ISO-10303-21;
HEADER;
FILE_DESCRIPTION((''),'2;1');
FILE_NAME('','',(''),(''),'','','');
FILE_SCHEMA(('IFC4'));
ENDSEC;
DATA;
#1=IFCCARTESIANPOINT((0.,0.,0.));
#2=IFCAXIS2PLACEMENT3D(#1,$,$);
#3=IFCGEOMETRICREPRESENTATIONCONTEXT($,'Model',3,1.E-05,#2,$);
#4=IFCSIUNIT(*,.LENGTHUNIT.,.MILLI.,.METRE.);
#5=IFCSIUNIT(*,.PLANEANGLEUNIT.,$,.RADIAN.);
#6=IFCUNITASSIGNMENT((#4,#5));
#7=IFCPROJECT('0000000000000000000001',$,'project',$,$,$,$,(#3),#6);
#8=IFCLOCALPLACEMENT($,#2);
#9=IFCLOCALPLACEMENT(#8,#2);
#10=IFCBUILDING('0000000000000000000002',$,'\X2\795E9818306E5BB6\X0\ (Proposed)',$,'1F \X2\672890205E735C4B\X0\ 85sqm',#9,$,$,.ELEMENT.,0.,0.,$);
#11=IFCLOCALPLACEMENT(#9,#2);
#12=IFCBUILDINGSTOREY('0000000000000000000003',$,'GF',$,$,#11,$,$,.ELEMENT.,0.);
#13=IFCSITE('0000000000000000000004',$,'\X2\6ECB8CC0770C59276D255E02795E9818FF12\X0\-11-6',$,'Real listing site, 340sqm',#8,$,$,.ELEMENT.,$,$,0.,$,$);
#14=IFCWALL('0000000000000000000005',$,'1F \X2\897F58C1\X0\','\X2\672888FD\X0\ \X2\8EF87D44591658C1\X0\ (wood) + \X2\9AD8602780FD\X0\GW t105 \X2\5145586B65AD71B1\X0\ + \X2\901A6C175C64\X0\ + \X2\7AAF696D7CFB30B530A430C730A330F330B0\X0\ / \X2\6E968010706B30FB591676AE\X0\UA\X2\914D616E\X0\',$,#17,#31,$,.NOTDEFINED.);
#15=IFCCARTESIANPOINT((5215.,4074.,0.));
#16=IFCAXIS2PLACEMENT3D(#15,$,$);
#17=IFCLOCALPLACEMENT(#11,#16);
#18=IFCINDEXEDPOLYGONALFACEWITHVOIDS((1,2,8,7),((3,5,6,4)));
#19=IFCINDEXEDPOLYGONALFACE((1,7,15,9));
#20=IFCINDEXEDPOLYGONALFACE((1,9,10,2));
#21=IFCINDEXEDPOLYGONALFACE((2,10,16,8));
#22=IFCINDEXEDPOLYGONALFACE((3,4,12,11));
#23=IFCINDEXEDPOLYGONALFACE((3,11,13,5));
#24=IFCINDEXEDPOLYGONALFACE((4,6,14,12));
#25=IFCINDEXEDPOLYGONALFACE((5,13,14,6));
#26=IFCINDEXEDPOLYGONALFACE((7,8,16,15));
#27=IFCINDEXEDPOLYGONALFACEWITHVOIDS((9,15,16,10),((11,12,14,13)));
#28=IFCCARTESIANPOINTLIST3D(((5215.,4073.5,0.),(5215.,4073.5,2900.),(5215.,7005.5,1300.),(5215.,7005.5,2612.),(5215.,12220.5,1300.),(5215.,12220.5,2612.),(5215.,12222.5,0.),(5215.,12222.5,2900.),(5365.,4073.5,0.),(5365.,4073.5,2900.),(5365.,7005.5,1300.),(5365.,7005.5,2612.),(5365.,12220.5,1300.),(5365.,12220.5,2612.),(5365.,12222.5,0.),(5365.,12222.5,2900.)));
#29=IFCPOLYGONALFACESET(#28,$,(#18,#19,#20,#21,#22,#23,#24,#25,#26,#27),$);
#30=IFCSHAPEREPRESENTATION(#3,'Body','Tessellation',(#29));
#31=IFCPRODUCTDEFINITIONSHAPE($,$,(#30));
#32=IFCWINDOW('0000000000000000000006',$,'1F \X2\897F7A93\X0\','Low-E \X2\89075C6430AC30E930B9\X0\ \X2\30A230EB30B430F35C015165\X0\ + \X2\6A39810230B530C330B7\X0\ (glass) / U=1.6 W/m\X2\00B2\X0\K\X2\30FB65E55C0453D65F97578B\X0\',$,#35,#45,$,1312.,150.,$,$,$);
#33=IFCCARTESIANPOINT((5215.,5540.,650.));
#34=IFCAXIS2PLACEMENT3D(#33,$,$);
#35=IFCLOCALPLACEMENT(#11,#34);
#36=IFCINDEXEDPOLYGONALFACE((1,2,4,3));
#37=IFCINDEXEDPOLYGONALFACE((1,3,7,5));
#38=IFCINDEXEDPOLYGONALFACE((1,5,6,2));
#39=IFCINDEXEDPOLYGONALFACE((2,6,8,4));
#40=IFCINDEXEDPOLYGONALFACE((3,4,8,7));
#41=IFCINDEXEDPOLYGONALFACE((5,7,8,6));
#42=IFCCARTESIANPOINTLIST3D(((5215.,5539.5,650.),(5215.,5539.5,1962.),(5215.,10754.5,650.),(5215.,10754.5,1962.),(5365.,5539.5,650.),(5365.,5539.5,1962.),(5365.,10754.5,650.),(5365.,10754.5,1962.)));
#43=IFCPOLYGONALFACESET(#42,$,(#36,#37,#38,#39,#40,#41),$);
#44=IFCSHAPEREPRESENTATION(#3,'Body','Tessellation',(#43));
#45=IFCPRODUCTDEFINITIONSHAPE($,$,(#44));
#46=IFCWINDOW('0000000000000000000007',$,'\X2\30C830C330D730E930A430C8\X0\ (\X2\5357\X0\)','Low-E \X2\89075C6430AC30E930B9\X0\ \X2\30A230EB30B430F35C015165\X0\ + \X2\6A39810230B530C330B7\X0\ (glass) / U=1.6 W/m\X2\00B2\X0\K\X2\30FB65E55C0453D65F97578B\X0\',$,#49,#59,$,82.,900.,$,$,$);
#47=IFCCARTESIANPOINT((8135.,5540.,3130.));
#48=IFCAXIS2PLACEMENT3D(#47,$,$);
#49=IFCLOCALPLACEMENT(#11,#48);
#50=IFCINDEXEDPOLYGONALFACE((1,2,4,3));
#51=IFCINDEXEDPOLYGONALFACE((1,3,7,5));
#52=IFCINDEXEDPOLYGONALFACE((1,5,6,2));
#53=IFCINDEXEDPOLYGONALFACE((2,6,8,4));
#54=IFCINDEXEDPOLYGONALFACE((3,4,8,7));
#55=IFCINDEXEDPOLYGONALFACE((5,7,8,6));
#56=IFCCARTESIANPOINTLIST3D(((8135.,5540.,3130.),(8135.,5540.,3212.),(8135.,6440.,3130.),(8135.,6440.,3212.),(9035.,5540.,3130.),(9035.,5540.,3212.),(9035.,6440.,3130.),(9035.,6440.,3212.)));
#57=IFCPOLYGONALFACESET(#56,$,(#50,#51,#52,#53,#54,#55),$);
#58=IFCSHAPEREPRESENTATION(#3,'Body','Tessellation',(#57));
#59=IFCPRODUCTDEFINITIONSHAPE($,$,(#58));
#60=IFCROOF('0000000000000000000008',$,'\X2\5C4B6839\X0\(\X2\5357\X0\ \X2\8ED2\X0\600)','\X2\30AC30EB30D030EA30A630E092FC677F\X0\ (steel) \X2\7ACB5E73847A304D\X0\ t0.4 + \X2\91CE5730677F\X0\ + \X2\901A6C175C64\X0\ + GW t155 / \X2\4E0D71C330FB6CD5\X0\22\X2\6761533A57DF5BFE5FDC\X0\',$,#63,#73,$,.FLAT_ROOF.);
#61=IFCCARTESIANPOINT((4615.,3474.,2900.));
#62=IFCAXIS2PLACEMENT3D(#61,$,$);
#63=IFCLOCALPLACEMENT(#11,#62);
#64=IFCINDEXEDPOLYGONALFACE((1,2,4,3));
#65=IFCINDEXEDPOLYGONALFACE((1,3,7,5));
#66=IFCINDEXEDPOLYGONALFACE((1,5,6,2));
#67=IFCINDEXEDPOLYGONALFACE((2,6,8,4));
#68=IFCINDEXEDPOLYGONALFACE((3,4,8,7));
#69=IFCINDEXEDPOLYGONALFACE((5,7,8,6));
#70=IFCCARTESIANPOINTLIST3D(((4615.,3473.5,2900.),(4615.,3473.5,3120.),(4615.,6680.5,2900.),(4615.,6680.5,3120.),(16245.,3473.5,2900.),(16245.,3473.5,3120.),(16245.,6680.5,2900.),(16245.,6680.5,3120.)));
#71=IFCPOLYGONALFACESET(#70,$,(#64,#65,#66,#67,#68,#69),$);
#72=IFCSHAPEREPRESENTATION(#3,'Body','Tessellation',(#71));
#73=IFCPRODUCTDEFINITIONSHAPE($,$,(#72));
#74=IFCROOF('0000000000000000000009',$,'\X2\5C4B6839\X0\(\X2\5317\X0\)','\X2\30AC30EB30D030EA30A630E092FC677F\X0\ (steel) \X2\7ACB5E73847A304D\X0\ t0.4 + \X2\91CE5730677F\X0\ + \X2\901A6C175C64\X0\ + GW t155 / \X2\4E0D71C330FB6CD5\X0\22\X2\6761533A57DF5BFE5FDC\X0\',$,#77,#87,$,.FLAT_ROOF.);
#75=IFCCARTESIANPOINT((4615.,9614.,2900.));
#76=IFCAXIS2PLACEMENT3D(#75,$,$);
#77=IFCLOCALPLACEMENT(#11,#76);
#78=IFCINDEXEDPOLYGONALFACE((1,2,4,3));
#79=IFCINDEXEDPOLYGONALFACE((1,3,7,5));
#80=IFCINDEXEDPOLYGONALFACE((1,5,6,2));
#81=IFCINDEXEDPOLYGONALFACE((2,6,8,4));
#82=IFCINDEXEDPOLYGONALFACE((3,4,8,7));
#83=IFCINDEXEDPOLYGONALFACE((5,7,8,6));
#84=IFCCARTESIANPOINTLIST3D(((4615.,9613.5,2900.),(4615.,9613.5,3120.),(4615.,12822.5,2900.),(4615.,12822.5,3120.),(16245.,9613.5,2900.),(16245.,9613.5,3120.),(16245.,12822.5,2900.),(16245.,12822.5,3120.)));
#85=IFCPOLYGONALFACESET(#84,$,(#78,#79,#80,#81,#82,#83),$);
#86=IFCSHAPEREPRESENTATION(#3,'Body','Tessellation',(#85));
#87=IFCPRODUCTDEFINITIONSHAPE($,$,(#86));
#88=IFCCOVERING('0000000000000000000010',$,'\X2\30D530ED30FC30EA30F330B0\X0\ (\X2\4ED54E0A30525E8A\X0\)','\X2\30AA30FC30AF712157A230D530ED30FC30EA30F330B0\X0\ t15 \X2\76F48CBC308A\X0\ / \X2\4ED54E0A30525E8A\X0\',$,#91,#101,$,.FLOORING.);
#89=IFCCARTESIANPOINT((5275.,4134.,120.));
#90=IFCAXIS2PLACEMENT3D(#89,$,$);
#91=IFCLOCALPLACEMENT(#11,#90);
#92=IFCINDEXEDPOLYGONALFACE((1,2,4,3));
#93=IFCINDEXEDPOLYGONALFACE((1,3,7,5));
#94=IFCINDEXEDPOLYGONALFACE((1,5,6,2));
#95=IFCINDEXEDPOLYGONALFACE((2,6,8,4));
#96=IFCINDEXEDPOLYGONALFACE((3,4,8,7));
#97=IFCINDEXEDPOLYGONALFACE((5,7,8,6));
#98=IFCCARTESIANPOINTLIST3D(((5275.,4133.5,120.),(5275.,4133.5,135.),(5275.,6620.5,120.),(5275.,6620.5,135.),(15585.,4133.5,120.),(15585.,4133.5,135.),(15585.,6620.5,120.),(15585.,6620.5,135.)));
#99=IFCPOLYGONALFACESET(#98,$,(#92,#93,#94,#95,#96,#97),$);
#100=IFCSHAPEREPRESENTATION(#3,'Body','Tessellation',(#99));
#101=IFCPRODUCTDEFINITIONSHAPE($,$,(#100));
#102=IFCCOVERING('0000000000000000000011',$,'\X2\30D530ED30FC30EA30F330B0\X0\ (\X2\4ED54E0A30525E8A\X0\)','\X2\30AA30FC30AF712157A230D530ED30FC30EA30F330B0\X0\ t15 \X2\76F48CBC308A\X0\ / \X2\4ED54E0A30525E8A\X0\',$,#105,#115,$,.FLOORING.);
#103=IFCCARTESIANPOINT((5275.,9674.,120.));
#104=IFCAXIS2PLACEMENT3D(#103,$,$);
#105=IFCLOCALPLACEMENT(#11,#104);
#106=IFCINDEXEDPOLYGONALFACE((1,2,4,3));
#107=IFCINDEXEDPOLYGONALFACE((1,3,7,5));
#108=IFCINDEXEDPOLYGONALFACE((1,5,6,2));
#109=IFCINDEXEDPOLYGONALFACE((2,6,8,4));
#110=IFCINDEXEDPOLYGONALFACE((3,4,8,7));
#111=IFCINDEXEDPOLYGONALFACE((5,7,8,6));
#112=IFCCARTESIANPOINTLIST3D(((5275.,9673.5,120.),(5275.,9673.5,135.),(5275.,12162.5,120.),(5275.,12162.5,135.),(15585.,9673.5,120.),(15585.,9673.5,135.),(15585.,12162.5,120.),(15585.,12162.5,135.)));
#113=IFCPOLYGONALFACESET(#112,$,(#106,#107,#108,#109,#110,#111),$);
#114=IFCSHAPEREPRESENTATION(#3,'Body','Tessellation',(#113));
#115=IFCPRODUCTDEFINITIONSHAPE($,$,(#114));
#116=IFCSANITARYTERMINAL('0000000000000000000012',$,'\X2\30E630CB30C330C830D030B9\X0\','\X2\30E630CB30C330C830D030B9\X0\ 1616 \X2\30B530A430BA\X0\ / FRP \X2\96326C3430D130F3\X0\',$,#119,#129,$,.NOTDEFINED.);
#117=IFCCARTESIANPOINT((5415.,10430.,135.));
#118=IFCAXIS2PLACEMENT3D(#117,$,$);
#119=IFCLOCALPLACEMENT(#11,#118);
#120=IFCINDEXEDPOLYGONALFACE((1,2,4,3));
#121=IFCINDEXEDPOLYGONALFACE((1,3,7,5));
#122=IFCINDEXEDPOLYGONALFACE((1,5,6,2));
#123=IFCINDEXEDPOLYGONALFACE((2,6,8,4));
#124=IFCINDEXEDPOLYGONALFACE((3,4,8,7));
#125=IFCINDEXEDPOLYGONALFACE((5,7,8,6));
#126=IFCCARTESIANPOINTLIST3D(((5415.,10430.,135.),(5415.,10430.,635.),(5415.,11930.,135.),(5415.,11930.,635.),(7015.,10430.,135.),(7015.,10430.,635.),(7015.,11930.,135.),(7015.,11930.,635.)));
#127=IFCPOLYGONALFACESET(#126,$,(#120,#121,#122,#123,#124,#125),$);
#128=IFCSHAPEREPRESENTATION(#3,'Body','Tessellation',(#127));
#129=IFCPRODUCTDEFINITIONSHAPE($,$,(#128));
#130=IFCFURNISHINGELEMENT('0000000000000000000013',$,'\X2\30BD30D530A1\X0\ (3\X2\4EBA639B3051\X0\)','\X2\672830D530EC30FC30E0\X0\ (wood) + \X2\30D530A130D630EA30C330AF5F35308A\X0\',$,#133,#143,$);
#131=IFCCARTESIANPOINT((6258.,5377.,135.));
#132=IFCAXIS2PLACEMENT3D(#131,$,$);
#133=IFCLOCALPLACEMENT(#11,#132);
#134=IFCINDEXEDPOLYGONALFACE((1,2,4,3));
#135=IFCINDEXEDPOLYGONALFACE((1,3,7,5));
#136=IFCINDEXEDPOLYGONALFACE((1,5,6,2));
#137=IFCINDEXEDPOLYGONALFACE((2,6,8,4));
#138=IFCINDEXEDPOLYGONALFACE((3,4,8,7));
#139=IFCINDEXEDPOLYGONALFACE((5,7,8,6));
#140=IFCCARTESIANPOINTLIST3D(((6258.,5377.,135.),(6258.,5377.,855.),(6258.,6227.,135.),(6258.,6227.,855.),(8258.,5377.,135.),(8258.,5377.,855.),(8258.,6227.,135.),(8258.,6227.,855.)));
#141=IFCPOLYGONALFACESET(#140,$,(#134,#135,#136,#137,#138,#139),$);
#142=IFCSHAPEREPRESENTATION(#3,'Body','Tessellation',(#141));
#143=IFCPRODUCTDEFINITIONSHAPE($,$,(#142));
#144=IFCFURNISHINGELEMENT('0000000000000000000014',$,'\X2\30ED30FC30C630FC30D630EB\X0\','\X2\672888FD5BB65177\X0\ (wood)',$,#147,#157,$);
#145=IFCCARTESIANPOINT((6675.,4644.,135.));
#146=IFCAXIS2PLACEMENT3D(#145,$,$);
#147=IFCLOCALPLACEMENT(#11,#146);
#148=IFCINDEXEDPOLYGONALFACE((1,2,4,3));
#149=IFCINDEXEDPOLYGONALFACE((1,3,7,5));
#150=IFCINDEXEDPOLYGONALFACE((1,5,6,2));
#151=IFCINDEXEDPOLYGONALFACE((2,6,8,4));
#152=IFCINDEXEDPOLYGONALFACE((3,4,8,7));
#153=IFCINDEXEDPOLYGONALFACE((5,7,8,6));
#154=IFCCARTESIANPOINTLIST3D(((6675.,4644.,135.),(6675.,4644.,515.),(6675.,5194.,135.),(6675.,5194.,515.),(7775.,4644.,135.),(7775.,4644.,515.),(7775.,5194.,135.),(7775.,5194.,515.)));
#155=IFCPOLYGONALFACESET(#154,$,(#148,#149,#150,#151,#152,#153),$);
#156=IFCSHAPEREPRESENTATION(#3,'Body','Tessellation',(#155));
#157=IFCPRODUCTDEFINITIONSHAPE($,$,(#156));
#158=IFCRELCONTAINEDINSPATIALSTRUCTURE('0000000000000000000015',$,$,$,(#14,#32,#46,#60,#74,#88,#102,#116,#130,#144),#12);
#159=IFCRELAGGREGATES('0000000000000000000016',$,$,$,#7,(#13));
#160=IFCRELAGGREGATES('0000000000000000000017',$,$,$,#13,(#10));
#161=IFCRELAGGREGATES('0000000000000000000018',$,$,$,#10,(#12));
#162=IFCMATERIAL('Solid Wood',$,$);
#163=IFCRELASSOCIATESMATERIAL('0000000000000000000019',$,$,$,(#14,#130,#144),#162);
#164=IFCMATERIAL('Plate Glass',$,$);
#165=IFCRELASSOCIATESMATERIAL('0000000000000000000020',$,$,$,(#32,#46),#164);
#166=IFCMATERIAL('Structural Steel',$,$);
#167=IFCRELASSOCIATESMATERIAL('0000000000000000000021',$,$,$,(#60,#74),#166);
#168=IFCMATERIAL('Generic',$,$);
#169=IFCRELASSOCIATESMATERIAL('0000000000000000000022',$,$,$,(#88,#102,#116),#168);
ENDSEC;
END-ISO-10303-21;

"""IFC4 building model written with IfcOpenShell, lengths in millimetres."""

from ifc_helpers import new_model, si_unit, frame, frame_2d, origin, place, context, project, spatial, rectangle, extrude, material, element, fill, save


model = new_model("IFC4")

# Units and contexts
model_context = context("Model", 3, precision=1e-05, world=origin())
ifc_project = project(units=[si_unit("LENGTHUNIT", "METRE", prefix="MILLI"), si_unit("PLANEANGLEUNIT", "RADIAN")], contexts=[model_context])

# Site, building, storey
site_placement = place(None, origin())
site = spatial("IfcSite", under=ifc_project, at=site_placement, Name="滋賀県大津市神領２-11-6", ObjectType="Real listing site, 340sqm", CompositionType="ELEMENT", RefElevation=0.0)
building_placement = place(site_placement, origin())
building = spatial("IfcBuilding", under=site, at=building_placement, Name="神領の家 (Proposed)", ObjectType="1F 木造平屋 85sqm", CompositionType="ELEMENT", ElevationOfRefHeight=0.0, ElevationOfTerrain=0.0)
storey_placement = place(building_placement, origin())
storey = spatial("IfcBuildingStorey", under=building, at=storey_placement, Name="GF", CompositionType="ELEMENT", Elevation=0.0)

# Shared definitions
ifc_material_1 = material(Name="Solid Wood")

# Shared definitions
ifc_material_2 = material(Name="Plate Glass")

# Wall, opening, window
wall_1_placement = place(storey_placement, frame((5215.0, 4074.0, 0.0)))
wall_1 = element("IfcWall", 1, at=wall_1_placement, inside=storey, material=ifc_material_1, Name="1F 西壁", Description="木製 軸組外壁 (wood) + 高性能GW t105 充填断熱 + 通気層 + 窯業系サイディング / 準耐火・外皮UA配慮", PredefinedType="NOTDEFINED", context=model_context, shape_type="SweptSolid", body=[
    extrude(rectangle(XDim=150.0, YDim=8149.0, at=frame_2d((75.0, 4074.0))), frame((5215.0, 4074.0, 0.0)), (0.0, 0.0, 1.0), 2900.0),
])
opening_1_placement = place(storey_placement, frame((5215.0, 5540.0, 650.0)))
opening_1 = element("IfcOpeningElement", 2, at=opening_1_placement, cuts=wall_1, PredefinedType="NOTDEFINED", context=model_context, shape_type="SweptSolid", body=[
    extrude(rectangle(XDim=150.0, YDim=5215.0, at=frame_2d((75.0, 2607.0))), frame((5215.0, 5540.0, 650.0)), (0.0, 0.0, 1.0), 1312.0),
])
window_1_placement = place(storey_placement, frame((5215.0, 5540.0, 650.0)))
window_1 = element("IfcWindow", 3, at=window_1_placement, inside=storey, material=ifc_material_2, Name="1F 西窓", Description="Low-E 複層ガラス アルゴン封入 + 樹脂サッシ (glass) / U=1.6 W/m²K・日射取得型", OverallHeight=1312.0, OverallWidth=150.0, context=model_context, shape_type="SweptSolid", body=[
    extrude(rectangle(XDim=150.0, YDim=5215.0, at=frame_2d((75.0, 2607.0))), frame((5215.0, 5540.0, 650.0)), (0.0, 0.0, 1.0), 1312.0),
])
fill(opening_1, window_1)

# Window
window_2_placement = place(storey_placement, frame((8135.0, 5540.0, 3130.0)))
element("IfcWindow", 4, at=window_2_placement, inside=storey, material=ifc_material_2, Name="トップライト (南)", Description="Low-E 複層ガラス アルゴン封入 + 樹脂サッシ (glass) / U=1.6 W/m²K・日射取得型", OverallHeight=82.0, OverallWidth=900.0, context=model_context, shape_type="SweptSolid", body=[
    extrude(rectangle(XDim=900.0, YDim=900.0, at=frame_2d((450.0, 450.0))), frame((8135.0, 5540.0, 3130.0)), (0.0, 0.0, 1.0), 82.0),
])

# Roofs
ifc_material_3 = material(Name="Structural Steel")
roof_1_placement = place(storey_placement, frame((4615.0, 3474.0, 2900.0)))
element("IfcRoof", 5, at=roof_1_placement, inside=storey, material=ifc_material_3, Name="屋根(南 軒600)", Description="ガルバリウム鋼板 (steel) 立平葺き t0.4 + 野地板 + 通気層 + GW t155 / 不燃・法22条区域対応", PredefinedType="FLAT_ROOF", context=model_context, shape_type="SweptSolid", body=[
    extrude(rectangle(XDim=11630.0, YDim=3207.0, at=frame_2d((5815.0, 1603.0))), frame((4615.0, 3474.0, 2900.0)), (0.0, 0.0, 1.0), 220.0),
])
roof_2_placement = place(storey_placement, frame((4615.0, 9614.0, 2900.0)))
element("IfcRoof", 6, at=roof_2_placement, inside=storey, material=ifc_material_3, Name="屋根(北)", Description="ガルバリウム鋼板 (steel) 立平葺き t0.4 + 野地板 + 通気層 + GW t155 / 不燃・法22条区域対応", PredefinedType="FLAT_ROOF", context=model_context, shape_type="SweptSolid", body=[
    extrude(rectangle(XDim=11630.0, YDim=3209.0, at=frame_2d((5815.0, 1604.0))), frame((4615.0, 9614.0, 2900.0)), (0.0, 0.0, 1.0), 220.0),
])

# Coverings
ifc_material_4 = material(Name="Generic")
covering_1_placement = place(storey_placement, frame((5275.0, 4134.0, 120.0)))
element("IfcCovering", 7, at=covering_1_placement, inside=storey, material=ifc_material_4, Name="フローリング (仕上げ床)", Description="オーク無垢フローリング t15 直貼り / 仕上げ床", PredefinedType="FLOORING", context=model_context, shape_type="SweptSolid", body=[
    extrude(rectangle(XDim=10310.0, YDim=2487.0, at=frame_2d((5155.0, 1243.0))), frame((5275.0, 4134.0, 120.0)), (0.0, 0.0, 1.0), 15.0),
])
covering_2_placement = place(storey_placement, frame((5275.0, 9674.0, 120.0)))
element("IfcCovering", 8, at=covering_2_placement, inside=storey, material=ifc_material_4, Name="フローリング (仕上げ床)", Description="オーク無垢フローリング t15 直貼り / 仕上げ床", PredefinedType="FLOORING", context=model_context, shape_type="SweptSolid", body=[
    extrude(rectangle(XDim=10310.0, YDim=2489.0, at=frame_2d((5155.0, 1244.0))), frame((5275.0, 9674.0, 120.0)), (0.0, 0.0, 1.0), 15.0),
])

# Sanitary terminal
sanitary_terminal_placement = place(storey_placement, frame((5415.0, 10430.0, 135.0)))
element("IfcSanitaryTerminal", 9, at=sanitary_terminal_placement, inside=storey, material=ifc_material_4, Name="ユニットバス", Description="ユニットバス 1616 サイズ / FRP 防水パン", PredefinedType="NOTDEFINED", context=model_context, shape_type="SweptSolid", body=[
    extrude(rectangle(XDim=1600.0, YDim=1500.0, at=frame_2d((800.0, 750.0))), frame((5415.0, 10430.0, 135.0)), (0.0, 0.0, 1.0), 500.0),
])

# Furnishing elements
furnishing_1_placement = place(storey_placement, frame((6258.0, 5377.0, 135.0)))
element("IfcFurnishingElement", 10, at=furnishing_1_placement, inside=storey, material=ifc_material_1, Name="ソファ (3人掛け)", Description="木フレーム (wood) + ファブリック張り", context=model_context, shape_type="SweptSolid", body=[
    extrude(rectangle(XDim=2000.0, YDim=850.0, at=frame_2d((1000.0, 425.0))), frame((6258.0, 5377.0, 135.0)), (0.0, 0.0, 1.0), 720.0),
])
furnishing_2_placement = place(storey_placement, frame((6675.0, 4644.0, 135.0)))
element("IfcFurnishingElement", 11, at=furnishing_2_placement, inside=storey, material=ifc_material_1, Name="ローテーブル", Description="木製家具 (wood)", context=model_context, shape_type="SweptSolid", body=[
    extrude(rectangle(XDim=1100.0, YDim=550.0, at=frame_2d((550.0, 275.0))), frame((6675.0, 4644.0, 135.0)), (0.0, 0.0, 1.0), 380.0),
])

save(model, "model.ifc")
